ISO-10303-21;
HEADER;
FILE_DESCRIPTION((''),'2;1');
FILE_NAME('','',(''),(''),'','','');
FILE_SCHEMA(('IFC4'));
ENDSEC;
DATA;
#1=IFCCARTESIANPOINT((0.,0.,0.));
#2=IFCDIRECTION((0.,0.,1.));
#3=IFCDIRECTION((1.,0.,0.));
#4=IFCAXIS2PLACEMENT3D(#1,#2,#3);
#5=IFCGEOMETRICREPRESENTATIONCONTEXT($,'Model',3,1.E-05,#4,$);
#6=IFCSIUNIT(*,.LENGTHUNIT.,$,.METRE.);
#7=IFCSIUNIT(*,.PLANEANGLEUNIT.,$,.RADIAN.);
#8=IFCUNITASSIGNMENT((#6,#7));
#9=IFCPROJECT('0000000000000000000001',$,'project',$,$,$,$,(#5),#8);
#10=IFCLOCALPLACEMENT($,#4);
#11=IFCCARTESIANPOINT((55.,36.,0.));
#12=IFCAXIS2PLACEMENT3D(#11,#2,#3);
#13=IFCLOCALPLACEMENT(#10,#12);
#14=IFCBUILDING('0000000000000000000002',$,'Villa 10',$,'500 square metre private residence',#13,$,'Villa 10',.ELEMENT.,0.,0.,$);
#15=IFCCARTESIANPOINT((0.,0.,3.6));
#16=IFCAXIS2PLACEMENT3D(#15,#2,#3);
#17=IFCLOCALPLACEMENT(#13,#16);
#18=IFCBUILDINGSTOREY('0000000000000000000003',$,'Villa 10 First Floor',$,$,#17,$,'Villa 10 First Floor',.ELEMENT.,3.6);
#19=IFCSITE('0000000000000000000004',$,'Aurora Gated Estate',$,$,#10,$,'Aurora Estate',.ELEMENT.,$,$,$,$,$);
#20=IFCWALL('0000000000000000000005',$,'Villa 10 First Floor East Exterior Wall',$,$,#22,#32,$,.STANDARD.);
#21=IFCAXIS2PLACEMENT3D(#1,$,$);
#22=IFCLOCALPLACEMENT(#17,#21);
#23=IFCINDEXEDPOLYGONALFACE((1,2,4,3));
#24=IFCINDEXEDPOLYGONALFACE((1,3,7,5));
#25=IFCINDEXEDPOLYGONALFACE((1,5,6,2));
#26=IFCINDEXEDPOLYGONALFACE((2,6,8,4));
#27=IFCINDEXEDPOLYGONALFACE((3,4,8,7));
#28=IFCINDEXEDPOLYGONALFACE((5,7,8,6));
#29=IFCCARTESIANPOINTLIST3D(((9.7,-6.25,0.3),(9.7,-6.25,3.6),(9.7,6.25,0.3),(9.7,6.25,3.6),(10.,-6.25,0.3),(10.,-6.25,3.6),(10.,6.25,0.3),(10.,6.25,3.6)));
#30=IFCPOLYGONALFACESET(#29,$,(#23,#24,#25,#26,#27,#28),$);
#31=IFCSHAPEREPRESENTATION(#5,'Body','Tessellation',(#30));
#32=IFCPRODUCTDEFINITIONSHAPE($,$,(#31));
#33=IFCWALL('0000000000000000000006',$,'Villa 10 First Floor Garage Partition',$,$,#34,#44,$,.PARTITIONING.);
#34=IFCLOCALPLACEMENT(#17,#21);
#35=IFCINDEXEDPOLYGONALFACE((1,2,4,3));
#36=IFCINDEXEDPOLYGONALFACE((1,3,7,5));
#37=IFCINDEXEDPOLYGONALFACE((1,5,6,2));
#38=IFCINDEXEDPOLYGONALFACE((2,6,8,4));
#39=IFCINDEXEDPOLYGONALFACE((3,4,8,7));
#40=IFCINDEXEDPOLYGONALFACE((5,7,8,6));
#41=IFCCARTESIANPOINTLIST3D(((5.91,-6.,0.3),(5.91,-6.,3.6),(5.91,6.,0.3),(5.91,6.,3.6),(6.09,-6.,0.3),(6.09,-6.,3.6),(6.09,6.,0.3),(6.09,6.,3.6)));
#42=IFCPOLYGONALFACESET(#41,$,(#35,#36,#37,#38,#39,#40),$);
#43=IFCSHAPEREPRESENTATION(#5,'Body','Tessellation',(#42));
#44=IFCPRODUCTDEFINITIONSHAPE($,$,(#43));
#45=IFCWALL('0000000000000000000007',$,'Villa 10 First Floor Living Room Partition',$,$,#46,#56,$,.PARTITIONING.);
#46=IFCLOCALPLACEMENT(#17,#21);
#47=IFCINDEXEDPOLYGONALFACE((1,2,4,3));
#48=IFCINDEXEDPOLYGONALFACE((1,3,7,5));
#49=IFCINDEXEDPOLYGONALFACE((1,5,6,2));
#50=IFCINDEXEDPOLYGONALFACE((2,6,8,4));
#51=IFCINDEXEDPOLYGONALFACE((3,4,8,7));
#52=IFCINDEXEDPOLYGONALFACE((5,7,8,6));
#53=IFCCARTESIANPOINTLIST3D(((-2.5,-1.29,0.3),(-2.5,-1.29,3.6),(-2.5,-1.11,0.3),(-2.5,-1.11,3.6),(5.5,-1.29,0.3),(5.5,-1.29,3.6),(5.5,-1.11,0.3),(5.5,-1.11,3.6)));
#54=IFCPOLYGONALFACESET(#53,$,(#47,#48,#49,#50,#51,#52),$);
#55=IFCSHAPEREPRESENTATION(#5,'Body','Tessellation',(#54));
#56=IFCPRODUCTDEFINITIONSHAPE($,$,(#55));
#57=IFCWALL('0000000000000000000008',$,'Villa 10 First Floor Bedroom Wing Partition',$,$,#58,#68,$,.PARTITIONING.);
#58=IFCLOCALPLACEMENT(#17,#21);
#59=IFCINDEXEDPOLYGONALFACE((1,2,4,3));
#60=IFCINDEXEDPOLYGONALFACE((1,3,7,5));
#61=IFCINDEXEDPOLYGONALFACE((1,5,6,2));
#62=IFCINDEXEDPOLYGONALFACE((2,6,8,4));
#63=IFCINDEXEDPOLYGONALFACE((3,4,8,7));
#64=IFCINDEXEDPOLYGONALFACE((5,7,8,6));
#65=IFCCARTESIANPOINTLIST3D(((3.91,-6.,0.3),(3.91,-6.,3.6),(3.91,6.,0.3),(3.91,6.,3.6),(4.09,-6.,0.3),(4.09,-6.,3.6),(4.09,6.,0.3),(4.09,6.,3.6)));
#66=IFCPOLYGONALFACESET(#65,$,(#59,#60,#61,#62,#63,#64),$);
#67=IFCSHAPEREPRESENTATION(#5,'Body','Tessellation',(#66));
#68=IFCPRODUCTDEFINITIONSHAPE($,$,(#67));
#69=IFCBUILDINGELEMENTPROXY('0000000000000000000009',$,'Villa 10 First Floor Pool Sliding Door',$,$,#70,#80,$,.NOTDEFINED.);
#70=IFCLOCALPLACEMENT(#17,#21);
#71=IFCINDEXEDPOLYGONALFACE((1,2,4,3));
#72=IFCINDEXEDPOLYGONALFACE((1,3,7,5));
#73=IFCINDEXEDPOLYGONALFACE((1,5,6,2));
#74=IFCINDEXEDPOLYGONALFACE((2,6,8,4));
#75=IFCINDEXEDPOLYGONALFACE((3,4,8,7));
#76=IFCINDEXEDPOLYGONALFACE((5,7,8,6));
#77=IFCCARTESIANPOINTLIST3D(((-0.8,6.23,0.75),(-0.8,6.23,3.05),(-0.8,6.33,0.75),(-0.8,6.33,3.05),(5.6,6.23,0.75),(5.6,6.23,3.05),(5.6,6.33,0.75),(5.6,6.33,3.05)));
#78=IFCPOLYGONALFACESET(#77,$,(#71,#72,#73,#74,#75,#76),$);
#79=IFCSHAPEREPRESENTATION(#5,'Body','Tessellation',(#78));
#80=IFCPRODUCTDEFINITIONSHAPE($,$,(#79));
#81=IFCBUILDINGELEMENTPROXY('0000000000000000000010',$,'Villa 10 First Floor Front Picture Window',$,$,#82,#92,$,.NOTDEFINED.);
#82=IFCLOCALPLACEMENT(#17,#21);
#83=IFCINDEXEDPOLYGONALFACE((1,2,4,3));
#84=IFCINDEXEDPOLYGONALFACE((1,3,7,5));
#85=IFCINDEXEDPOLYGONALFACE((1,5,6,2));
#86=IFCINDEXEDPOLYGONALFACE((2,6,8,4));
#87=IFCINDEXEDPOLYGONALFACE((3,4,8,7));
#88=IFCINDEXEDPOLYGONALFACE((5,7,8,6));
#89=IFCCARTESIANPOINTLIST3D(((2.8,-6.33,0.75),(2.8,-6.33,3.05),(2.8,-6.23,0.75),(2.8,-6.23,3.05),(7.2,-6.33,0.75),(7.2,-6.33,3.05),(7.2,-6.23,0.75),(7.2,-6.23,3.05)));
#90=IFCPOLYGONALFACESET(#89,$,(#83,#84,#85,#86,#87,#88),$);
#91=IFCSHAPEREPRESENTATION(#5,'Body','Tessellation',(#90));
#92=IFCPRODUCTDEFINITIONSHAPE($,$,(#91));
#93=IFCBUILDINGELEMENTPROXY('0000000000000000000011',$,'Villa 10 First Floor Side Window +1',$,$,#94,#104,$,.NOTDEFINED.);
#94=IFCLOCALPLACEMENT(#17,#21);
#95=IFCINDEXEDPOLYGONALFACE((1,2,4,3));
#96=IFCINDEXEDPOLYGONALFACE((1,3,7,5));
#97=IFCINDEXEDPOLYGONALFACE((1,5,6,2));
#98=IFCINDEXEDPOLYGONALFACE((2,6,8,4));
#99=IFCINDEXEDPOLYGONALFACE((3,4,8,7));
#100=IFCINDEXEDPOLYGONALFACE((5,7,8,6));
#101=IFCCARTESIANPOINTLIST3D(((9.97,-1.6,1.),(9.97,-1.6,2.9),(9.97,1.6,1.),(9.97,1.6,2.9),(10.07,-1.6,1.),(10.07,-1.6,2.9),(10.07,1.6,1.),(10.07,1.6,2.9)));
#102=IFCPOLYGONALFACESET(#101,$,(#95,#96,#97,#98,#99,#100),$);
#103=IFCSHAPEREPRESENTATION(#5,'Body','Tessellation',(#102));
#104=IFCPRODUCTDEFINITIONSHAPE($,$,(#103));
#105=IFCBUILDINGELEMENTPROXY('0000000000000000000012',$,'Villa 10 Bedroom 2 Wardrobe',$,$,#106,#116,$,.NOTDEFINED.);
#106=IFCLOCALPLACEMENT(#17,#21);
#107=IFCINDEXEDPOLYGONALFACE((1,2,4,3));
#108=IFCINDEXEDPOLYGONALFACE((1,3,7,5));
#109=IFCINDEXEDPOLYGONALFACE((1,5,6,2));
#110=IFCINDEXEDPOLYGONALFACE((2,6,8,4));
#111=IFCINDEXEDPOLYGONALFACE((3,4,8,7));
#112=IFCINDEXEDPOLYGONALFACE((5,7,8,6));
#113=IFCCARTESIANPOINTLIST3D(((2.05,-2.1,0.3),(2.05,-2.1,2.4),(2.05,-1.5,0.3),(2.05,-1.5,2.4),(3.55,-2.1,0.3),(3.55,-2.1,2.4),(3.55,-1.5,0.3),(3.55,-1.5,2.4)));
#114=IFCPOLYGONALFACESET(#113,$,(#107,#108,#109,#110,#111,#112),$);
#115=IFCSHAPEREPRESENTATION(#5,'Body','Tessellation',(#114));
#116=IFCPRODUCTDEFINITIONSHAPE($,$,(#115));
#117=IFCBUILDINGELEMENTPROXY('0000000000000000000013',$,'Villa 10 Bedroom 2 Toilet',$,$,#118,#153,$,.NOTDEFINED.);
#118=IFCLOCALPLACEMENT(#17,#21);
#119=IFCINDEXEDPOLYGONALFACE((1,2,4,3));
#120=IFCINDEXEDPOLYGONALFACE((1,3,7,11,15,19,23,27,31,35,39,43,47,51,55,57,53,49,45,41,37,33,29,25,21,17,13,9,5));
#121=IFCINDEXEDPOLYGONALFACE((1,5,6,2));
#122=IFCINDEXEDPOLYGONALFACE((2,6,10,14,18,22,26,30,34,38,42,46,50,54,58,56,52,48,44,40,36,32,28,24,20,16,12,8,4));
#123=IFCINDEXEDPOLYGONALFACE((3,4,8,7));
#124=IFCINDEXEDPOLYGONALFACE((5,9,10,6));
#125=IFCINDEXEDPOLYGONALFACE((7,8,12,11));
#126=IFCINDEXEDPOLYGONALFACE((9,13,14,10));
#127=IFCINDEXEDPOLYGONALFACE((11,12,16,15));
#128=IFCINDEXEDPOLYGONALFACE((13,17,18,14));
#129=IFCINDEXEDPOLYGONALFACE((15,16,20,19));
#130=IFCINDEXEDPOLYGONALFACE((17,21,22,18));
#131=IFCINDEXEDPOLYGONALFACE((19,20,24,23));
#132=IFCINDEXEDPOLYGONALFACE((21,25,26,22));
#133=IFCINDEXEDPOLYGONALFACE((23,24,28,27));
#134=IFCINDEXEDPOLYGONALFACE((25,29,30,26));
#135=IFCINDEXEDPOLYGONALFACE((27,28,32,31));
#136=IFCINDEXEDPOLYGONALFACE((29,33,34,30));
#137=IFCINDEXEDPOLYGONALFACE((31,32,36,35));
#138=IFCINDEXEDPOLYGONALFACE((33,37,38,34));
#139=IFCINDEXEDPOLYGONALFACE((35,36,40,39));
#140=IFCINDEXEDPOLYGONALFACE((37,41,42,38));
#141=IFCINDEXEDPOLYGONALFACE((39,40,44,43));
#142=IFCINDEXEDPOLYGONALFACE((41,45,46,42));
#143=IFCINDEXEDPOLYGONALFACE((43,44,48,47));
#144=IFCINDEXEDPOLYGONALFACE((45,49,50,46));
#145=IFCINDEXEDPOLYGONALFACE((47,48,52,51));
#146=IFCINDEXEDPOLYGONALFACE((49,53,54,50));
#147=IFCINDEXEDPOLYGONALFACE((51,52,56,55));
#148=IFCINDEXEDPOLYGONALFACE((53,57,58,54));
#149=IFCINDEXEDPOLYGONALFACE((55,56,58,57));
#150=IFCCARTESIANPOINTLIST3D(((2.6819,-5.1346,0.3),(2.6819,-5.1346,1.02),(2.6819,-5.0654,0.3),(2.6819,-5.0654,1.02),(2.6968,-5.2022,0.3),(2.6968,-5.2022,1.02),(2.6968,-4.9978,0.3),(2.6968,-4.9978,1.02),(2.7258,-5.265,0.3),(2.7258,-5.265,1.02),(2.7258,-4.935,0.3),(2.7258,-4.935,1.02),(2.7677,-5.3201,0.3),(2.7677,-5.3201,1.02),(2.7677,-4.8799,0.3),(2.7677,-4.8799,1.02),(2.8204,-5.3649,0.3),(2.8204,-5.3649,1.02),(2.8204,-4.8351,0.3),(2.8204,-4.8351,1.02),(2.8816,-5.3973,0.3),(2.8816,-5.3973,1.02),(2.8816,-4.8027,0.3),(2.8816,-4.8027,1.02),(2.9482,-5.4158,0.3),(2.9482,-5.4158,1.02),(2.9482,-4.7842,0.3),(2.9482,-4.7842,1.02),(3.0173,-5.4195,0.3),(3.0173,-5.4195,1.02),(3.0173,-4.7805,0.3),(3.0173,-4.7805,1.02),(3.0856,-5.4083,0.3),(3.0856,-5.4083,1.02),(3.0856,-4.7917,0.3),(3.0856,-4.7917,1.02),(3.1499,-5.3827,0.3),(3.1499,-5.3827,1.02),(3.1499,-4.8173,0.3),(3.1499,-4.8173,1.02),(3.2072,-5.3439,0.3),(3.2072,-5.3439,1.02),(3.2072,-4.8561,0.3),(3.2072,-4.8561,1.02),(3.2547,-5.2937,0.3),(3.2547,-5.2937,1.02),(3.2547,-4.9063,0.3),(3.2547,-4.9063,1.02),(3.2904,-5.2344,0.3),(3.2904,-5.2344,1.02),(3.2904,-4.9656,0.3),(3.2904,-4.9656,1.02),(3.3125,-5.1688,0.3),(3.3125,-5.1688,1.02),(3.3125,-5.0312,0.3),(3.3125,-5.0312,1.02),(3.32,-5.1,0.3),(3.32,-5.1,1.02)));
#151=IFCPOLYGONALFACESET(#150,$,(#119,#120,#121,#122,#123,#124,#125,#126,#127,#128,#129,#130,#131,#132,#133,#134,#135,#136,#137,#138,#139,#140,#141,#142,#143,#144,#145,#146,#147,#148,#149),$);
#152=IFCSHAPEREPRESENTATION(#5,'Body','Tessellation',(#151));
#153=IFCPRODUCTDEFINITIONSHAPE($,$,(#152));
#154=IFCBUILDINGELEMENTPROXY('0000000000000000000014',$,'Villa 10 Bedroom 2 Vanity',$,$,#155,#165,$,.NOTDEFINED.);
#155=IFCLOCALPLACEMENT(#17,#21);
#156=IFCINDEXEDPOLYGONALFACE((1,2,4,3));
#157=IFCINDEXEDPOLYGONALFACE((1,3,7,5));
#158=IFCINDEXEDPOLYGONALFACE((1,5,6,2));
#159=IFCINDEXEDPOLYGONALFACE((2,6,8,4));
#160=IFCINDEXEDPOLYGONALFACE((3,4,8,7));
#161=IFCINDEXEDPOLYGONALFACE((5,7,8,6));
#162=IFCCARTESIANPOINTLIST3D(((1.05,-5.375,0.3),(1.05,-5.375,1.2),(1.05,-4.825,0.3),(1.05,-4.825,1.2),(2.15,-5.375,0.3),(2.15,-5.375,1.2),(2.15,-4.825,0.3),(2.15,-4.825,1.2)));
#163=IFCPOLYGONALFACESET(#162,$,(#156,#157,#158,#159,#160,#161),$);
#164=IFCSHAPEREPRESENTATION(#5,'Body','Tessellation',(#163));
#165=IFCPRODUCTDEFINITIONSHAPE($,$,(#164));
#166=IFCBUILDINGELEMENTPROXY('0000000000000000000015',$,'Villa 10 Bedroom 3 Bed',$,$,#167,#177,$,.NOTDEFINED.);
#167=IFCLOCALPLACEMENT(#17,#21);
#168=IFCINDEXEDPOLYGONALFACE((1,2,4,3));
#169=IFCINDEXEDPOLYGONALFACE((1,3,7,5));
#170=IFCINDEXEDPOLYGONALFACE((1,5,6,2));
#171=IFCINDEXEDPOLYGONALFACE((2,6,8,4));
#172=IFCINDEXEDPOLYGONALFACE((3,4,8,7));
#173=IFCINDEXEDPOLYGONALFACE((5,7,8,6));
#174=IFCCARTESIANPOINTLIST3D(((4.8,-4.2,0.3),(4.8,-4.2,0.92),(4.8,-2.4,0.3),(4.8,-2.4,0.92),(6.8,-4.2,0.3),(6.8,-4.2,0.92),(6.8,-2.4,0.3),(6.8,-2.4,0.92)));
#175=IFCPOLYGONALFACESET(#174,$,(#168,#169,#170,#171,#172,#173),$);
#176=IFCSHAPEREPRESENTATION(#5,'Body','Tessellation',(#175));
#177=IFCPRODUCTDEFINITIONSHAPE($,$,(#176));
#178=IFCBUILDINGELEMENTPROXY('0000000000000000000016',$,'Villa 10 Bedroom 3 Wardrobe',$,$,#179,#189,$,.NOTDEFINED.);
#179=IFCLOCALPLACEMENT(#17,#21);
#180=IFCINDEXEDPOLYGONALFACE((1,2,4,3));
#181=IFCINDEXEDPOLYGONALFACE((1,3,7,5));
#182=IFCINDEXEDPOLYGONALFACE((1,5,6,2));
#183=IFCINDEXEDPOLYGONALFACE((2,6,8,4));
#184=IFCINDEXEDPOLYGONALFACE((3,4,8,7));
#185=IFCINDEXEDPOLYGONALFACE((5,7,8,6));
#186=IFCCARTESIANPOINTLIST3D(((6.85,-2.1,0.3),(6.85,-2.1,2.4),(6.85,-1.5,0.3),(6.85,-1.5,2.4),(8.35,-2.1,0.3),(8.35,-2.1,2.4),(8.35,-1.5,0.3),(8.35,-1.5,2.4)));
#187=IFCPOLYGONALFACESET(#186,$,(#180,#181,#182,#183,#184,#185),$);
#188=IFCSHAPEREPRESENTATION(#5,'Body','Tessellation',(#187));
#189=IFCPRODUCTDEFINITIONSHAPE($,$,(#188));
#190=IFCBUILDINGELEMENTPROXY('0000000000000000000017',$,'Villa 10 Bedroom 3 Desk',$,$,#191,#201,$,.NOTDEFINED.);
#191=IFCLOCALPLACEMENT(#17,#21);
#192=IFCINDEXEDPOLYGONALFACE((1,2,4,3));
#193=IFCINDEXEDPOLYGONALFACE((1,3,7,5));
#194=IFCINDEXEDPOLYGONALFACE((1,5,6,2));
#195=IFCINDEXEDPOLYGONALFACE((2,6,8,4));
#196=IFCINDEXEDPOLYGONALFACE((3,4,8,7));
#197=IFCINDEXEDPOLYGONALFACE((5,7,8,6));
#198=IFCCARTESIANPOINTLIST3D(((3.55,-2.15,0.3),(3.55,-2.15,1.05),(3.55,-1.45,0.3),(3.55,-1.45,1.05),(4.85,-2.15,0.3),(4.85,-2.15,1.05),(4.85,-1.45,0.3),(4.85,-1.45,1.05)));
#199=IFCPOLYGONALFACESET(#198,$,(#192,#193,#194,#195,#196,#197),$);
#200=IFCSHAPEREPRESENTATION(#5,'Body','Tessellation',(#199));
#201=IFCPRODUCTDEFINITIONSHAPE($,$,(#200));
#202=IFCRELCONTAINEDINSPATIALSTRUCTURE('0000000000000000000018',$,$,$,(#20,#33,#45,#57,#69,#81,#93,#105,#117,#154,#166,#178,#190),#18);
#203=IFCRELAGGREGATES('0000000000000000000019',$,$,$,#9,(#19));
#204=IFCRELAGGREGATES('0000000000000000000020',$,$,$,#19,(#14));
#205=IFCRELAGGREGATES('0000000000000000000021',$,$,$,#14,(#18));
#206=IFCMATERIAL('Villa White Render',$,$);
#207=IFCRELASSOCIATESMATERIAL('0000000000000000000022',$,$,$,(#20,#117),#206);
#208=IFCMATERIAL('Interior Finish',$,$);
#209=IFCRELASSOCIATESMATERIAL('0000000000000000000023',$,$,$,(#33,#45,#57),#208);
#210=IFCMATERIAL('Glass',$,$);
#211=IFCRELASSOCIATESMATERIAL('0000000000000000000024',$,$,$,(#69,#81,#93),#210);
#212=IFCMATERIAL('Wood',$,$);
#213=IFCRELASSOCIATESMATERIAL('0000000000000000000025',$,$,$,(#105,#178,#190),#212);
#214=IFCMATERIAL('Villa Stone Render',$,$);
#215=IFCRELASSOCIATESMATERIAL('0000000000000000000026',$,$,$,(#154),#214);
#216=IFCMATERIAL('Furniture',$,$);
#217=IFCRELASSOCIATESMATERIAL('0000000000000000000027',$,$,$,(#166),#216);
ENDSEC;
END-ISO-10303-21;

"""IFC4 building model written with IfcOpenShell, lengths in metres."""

from ifc_helpers import new_model, si_unit, frame, origin_with_axes, origin_2d_with_axis, place, context, project, spatial, rectangle, circle, extrude, material, element, save


model = new_model("IFC4")

# Units and contexts
model_context = context("Model", 3, precision=1e-05, world=origin_with_axes())
ifc_project = project(units=[si_unit("LENGTHUNIT", "METRE"), si_unit("PLANEANGLEUNIT", "RADIAN")], contexts=[model_context])

# Site, building, storey
site_placement = place(None, origin_with_axes())
site = spatial("IfcSite", under=ifc_project, at=site_placement, Name="Aurora Gated Estate", LongName="Aurora Estate", CompositionType="ELEMENT")
building_placement = place(site_placement, frame((55.0, 36.0, 0.0), z_axis=(0.0, 0.0, 1.0), x_axis=(1.0, 0.0, 0.0)))
building = spatial("IfcBuilding", under=site, at=building_placement, Name="Villa 10", ObjectType="500 square metre private residence", LongName="Villa 10", CompositionType="ELEMENT", ElevationOfRefHeight=0.0, ElevationOfTerrain=0.0)
storey_placement = place(building_placement, frame((0.0, 0.0, 3.6), z_axis=(0.0, 0.0, 1.0), x_axis=(1.0, 0.0, 0.0)))
storey = spatial("IfcBuildingStorey", under=building, at=storey_placement, Name="Villa 10 First Floor", LongName="Villa 10 First Floor", CompositionType="ELEMENT", Elevation=3.6)

# Walls
ifc_material_1 = material(Name="Villa White Render")
wall_1_placement = place(storey_placement, frame((9.85, 0.0, 0.3), z_axis=(0.0, 0.0, 1.0), x_axis=(1.0, 0.0, 0.0)))
element("IfcWall", 1, at=wall_1_placement, inside=storey, material=ifc_material_1, Name="Villa 10 First Floor East Exterior Wall", PredefinedType="STANDARD", context=model_context, shape_type="SweptSolid", body=[
    extrude(rectangle(XDim=0.3, YDim=12.5, at=origin_2d_with_axis()), origin_with_axes(), (0.0, 0.0, 1.0), 3.3),
])
ifc_material_2 = material(Name="Interior Finish")
wall_2_placement = place(storey_placement, frame((6.0, 0.0, 0.3), z_axis=(0.0, 0.0, 1.0), x_axis=(1.0, 0.0, 0.0)))
element("IfcWall", 2, at=wall_2_placement, inside=storey, material=ifc_material_2, Name="Villa 10 First Floor Garage Partition", PredefinedType="PARTITIONING", context=model_context, shape_type="SweptSolid", body=[
    extrude(rectangle(XDim=0.18, YDim=12.0, at=origin_2d_with_axis()), origin_with_axes(), (0.0, 0.0, 1.0), 3.3),
])
wall_3_placement = place(storey_placement, frame((1.5, -1.2, 0.3), z_axis=(0.0, 0.0, 1.0), x_axis=(1.0, 0.0, 0.0)))
element("IfcWall", 3, at=wall_3_placement, inside=storey, material=ifc_material_2, Name="Villa 10 First Floor Living Room Partition", PredefinedType="PARTITIONING", context=model_context, shape_type="SweptSolid", body=[
    extrude(rectangle(XDim=8.0, YDim=0.18, at=origin_2d_with_axis()), origin_with_axes(), (0.0, 0.0, 1.0), 3.3),
])
wall_4_placement = place(storey_placement, frame((4.0, 0.0, 0.3), z_axis=(0.0, 0.0, 1.0), x_axis=(1.0, 0.0, 0.0)))
element("IfcWall", 4, at=wall_4_placement, inside=storey, material=ifc_material_2, Name="Villa 10 First Floor Bedroom Wing Partition", PredefinedType="PARTITIONING", context=model_context, shape_type="SweptSolid", body=[
    extrude(rectangle(XDim=0.18, YDim=12.0, at=origin_2d_with_axis()), origin_with_axes(), (0.0, 0.0, 1.0), 3.3),
])

# Building element proxies
ifc_material_3 = material(Name="Glass")
proxy_1_placement = place(storey_placement, frame((2.4, 6.28, 0.75), z_axis=(0.0, 0.0, 1.0), x_axis=(1.0, 0.0, 0.0)))
element("IfcBuildingElementProxy", 5, at=proxy_1_placement, inside=storey, material=ifc_material_3, Name="Villa 10 First Floor Pool Sliding Door", PredefinedType="NOTDEFINED", context=model_context, shape_type="SweptSolid", body=[
    extrude(rectangle(XDim=6.4, YDim=0.1, at=origin_2d_with_axis()), origin_with_axes(), (0.0, 0.0, 1.0), 2.3),
])
proxy_2_placement = place(storey_placement, frame((5.0, -6.28, 0.75), z_axis=(0.0, 0.0, 1.0), x_axis=(1.0, 0.0, 0.0)))
element("IfcBuildingElementProxy", 6, at=proxy_2_placement, inside=storey, material=ifc_material_3, Name="Villa 10 First Floor Front Picture Window", PredefinedType="NOTDEFINED", context=model_context, shape_type="SweptSolid", body=[
    extrude(rectangle(XDim=4.4, YDim=0.1, at=origin_2d_with_axis()), origin_with_axes(), (0.0, 0.0, 1.0), 2.3),
])
proxy_3_placement = place(storey_placement, frame((10.02, 0.0, 1.0), z_axis=(0.0, 0.0, 1.0), x_axis=(0.0, 1.0, 0.0)))
element("IfcBuildingElementProxy", 7, at=proxy_3_placement, inside=storey, material=ifc_material_3, Name="Villa 10 First Floor Side Window +1", PredefinedType="NOTDEFINED", context=model_context, shape_type="SweptSolid", body=[
    extrude(rectangle(XDim=3.2, YDim=0.1, at=origin_2d_with_axis()), origin_with_axes(), (0.0, 0.0, 1.0), 1.9),
])
ifc_material_4 = material(Name="Wood")
proxy_4_placement = place(storey_placement, frame((2.8, -1.8, 0.3), z_axis=(0.0, 0.0, 1.0), x_axis=(1.0, 0.0, 0.0)))
element("IfcBuildingElementProxy", 8, at=proxy_4_placement, inside=storey, material=ifc_material_4, Name="Villa 10 Bedroom 2 Wardrobe", PredefinedType="NOTDEFINED", context=model_context, shape_type="SweptSolid", body=[
    extrude(rectangle(XDim=1.5, YDim=0.6, at=origin_2d_with_axis()), origin_with_axes(), (0.0, 0.0, 1.0), 2.1),
])
proxy_5_placement = place(storey_placement, frame((3.0, -5.1, 0.3), z_axis=(0.0, 0.0, 1.0), x_axis=(1.0, 0.0, 0.0)))
element("IfcBuildingElementProxy", 9, at=proxy_5_placement, inside=storey, material=ifc_material_1, Name="Villa 10 Bedroom 2 Toilet", PredefinedType="NOTDEFINED", context=model_context, shape_type="SweptSolid", body=[
    extrude(circle(Radius=0.32, at=origin_2d_with_axis()), origin_with_axes(), (0.0, 0.0, 1.0), 0.72),
])
ifc_material_5 = material(Name="Villa Stone Render")
proxy_6_placement = place(storey_placement, frame((1.6, -5.1, 0.3), z_axis=(0.0, 0.0, 1.0), x_axis=(1.0, 0.0, 0.0)))
element("IfcBuildingElementProxy", 10, at=proxy_6_placement, inside=storey, material=ifc_material_5, Name="Villa 10 Bedroom 2 Vanity", PredefinedType="NOTDEFINED", context=model_context, shape_type="SweptSolid", body=[
    extrude(rectangle(XDim=1.1, YDim=0.55, at=origin_2d_with_axis()), origin_with_axes(), (0.0, 0.0, 1.0), 0.9),
])
ifc_material_6 = material(Name="Furniture")
proxy_7_placement = place(storey_placement, frame((5.8, -3.3, 0.3), z_axis=(0.0, 0.0, 1.0), x_axis=(1.0, 0.0, 0.0)))
element("IfcBuildingElementProxy", 11, at=proxy_7_placement, inside=storey, material=ifc_material_6, Name="Villa 10 Bedroom 3 Bed", PredefinedType="NOTDEFINED", context=model_context, shape_type="SweptSolid", body=[
    extrude(rectangle(XDim=2.0, YDim=1.8, at=origin_2d_with_axis()), origin_with_axes(), (0.0, 0.0, 1.0), 0.62),
])
proxy_8_placement = place(storey_placement, frame((7.6, -1.8, 0.3), z_axis=(0.0, 0.0, 1.0), x_axis=(1.0, 0.0, 0.0)))
element("IfcBuildingElementProxy", 12, at=proxy_8_placement, inside=storey, material=ifc_material_4, Name="Villa 10 Bedroom 3 Wardrobe", PredefinedType="NOTDEFINED", context=model_context, shape_type="SweptSolid", body=[
    extrude(rectangle(XDim=1.5, YDim=0.6, at=origin_2d_with_axis()), origin_with_axes(), (0.0, 0.0, 1.0), 2.1),
])
proxy_9_placement = place(storey_placement, frame((4.2, -1.8, 0.3), z_axis=(0.0, 0.0, 1.0), x_axis=(1.0, 0.0, 0.0)))
element("IfcBuildingElementProxy", 13, at=proxy_9_placement, inside=storey, material=ifc_material_4, Name="Villa 10 Bedroom 3 Desk", PredefinedType="NOTDEFINED", context=model_context, shape_type="SweptSolid", body=[
    extrude(rectangle(XDim=1.3, YDim=0.7, at=origin_2d_with_axis()), origin_with_axes(), (0.0, 0.0, 1.0), 0.75),
])

save(model, "model.ifc")
